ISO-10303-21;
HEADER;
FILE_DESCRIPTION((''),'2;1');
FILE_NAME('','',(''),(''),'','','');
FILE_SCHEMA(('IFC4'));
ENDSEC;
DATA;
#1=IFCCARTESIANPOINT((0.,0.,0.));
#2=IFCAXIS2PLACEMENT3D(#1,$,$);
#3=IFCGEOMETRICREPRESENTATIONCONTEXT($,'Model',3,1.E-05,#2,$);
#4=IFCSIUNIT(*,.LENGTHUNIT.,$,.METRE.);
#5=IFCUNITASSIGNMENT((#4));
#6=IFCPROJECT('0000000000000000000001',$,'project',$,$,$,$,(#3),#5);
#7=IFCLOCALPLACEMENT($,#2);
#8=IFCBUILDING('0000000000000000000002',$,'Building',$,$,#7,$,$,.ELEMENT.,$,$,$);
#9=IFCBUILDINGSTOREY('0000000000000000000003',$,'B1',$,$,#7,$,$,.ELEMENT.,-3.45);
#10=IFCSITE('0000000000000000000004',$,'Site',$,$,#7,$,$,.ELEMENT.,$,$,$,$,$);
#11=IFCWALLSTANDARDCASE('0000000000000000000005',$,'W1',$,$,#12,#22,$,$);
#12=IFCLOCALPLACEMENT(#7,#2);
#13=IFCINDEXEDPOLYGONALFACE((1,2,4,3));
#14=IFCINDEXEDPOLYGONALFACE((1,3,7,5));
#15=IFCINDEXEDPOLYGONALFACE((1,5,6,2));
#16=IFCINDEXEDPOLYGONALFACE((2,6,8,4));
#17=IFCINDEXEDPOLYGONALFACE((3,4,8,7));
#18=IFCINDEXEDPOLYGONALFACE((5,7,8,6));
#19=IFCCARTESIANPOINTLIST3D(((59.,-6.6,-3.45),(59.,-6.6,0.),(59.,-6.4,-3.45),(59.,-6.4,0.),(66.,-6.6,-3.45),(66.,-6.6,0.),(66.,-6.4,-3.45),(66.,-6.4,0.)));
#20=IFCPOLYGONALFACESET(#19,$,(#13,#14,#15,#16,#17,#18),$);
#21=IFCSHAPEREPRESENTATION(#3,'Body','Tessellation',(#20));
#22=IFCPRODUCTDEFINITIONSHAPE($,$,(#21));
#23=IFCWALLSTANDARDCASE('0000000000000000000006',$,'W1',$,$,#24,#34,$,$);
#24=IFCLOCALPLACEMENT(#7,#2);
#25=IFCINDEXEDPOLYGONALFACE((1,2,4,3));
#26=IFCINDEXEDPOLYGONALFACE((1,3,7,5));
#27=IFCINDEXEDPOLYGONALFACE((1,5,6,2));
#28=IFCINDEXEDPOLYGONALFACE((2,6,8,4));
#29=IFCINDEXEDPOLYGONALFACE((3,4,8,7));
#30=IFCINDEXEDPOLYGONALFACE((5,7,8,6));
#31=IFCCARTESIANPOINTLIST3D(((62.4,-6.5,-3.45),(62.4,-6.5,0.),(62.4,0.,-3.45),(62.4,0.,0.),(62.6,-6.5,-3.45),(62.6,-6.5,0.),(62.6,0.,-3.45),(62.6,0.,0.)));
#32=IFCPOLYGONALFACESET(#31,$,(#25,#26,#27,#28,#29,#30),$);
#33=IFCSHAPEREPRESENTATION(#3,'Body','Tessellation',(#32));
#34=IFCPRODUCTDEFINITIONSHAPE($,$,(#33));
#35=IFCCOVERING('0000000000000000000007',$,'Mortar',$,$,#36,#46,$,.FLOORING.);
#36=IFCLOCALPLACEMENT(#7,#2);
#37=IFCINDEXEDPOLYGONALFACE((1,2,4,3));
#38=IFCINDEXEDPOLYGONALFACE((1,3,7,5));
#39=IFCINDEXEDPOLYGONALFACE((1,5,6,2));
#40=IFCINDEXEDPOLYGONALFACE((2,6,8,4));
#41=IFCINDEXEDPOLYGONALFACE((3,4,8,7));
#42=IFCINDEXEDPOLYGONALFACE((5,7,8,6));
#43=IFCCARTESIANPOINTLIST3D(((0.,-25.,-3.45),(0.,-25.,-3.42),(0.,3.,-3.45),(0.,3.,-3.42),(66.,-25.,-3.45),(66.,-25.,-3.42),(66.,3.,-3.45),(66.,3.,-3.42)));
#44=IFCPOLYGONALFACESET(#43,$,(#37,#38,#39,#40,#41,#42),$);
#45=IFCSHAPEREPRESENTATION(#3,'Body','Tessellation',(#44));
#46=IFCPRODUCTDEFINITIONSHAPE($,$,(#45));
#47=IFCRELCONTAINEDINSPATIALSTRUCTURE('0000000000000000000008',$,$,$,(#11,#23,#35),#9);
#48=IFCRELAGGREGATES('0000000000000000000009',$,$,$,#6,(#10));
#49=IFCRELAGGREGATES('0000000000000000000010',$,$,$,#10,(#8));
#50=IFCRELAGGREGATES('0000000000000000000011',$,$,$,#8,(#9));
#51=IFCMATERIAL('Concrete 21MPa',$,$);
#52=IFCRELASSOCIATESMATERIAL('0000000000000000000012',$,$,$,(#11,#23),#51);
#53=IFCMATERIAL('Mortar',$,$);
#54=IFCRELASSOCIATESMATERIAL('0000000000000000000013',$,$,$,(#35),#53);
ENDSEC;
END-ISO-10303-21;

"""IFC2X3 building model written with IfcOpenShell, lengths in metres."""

from ifc_helpers import new_model, si_unit, frame, origin, origin_2d, place, context, project, spatial, rectangle, extrude, material, element, save


model = new_model("IFC2X3")

# Units and contexts
model_context = context("Model", 3, precision=1e-05, world=origin())
ifc_project = project(units=[si_unit("LENGTHUNIT", "METRE")], contexts=[model_context])

# Site, building, storey
placement = place(None, origin())
site = spatial("IfcSite", under=ifc_project, at=placement, Name="Site", CompositionType="ELEMENT")
building = spatial("IfcBuilding", under=site, at=placement, Name="Building", CompositionType="ELEMENT")
storey = spatial("IfcBuildingStorey", under=building, at=placement, Name="B1", CompositionType="ELEMENT", Elevation=-3.45)

# Shared definitions
ifc_material_1 = material(Name="Concrete 21MPa")

# Walls
wall_1_placement = place(None, frame((62.5, -6.5, -3.45)))
element("IfcWallStandardCase", 1, at=wall_1_placement, inside=storey, material=ifc_material_1, Name="W1", context=model_context, shape_type="SweptSolid", body=[
    extrude(rectangle(XDim=7.0, YDim=0.2, at=origin_2d()), origin(), (0.0, 0.0, 1.0), 3.45),
])
wall_2_placement = place(None, frame((62.5, -3.25, -3.45)))
element("IfcWallStandardCase", 2, at=wall_2_placement, inside=storey, material=ifc_material_1, Name="W1", context=model_context, shape_type="SweptSolid", body=[
    extrude(rectangle(XDim=0.2, YDim=6.5, at=origin_2d()), origin(), (0.0, 0.0, 1.0), 3.45),
])

# Covering
ifc_material_2 = material(Name="Mortar")
covering_placement = place(None, frame((33.0, -11.0, -3.45)))
element("IfcCovering", 3, at=covering_placement, inside=storey, material=ifc_material_2, Name="Mortar", PredefinedType="FLOORING", context=model_context, shape_type="SweptSolid", body=[
    extrude(rectangle(XDim=66.0, YDim=28.0, at=origin_2d()), origin(), (0.0, 0.0, 1.0), 0.03),
])

save(model, "model.ifc")
